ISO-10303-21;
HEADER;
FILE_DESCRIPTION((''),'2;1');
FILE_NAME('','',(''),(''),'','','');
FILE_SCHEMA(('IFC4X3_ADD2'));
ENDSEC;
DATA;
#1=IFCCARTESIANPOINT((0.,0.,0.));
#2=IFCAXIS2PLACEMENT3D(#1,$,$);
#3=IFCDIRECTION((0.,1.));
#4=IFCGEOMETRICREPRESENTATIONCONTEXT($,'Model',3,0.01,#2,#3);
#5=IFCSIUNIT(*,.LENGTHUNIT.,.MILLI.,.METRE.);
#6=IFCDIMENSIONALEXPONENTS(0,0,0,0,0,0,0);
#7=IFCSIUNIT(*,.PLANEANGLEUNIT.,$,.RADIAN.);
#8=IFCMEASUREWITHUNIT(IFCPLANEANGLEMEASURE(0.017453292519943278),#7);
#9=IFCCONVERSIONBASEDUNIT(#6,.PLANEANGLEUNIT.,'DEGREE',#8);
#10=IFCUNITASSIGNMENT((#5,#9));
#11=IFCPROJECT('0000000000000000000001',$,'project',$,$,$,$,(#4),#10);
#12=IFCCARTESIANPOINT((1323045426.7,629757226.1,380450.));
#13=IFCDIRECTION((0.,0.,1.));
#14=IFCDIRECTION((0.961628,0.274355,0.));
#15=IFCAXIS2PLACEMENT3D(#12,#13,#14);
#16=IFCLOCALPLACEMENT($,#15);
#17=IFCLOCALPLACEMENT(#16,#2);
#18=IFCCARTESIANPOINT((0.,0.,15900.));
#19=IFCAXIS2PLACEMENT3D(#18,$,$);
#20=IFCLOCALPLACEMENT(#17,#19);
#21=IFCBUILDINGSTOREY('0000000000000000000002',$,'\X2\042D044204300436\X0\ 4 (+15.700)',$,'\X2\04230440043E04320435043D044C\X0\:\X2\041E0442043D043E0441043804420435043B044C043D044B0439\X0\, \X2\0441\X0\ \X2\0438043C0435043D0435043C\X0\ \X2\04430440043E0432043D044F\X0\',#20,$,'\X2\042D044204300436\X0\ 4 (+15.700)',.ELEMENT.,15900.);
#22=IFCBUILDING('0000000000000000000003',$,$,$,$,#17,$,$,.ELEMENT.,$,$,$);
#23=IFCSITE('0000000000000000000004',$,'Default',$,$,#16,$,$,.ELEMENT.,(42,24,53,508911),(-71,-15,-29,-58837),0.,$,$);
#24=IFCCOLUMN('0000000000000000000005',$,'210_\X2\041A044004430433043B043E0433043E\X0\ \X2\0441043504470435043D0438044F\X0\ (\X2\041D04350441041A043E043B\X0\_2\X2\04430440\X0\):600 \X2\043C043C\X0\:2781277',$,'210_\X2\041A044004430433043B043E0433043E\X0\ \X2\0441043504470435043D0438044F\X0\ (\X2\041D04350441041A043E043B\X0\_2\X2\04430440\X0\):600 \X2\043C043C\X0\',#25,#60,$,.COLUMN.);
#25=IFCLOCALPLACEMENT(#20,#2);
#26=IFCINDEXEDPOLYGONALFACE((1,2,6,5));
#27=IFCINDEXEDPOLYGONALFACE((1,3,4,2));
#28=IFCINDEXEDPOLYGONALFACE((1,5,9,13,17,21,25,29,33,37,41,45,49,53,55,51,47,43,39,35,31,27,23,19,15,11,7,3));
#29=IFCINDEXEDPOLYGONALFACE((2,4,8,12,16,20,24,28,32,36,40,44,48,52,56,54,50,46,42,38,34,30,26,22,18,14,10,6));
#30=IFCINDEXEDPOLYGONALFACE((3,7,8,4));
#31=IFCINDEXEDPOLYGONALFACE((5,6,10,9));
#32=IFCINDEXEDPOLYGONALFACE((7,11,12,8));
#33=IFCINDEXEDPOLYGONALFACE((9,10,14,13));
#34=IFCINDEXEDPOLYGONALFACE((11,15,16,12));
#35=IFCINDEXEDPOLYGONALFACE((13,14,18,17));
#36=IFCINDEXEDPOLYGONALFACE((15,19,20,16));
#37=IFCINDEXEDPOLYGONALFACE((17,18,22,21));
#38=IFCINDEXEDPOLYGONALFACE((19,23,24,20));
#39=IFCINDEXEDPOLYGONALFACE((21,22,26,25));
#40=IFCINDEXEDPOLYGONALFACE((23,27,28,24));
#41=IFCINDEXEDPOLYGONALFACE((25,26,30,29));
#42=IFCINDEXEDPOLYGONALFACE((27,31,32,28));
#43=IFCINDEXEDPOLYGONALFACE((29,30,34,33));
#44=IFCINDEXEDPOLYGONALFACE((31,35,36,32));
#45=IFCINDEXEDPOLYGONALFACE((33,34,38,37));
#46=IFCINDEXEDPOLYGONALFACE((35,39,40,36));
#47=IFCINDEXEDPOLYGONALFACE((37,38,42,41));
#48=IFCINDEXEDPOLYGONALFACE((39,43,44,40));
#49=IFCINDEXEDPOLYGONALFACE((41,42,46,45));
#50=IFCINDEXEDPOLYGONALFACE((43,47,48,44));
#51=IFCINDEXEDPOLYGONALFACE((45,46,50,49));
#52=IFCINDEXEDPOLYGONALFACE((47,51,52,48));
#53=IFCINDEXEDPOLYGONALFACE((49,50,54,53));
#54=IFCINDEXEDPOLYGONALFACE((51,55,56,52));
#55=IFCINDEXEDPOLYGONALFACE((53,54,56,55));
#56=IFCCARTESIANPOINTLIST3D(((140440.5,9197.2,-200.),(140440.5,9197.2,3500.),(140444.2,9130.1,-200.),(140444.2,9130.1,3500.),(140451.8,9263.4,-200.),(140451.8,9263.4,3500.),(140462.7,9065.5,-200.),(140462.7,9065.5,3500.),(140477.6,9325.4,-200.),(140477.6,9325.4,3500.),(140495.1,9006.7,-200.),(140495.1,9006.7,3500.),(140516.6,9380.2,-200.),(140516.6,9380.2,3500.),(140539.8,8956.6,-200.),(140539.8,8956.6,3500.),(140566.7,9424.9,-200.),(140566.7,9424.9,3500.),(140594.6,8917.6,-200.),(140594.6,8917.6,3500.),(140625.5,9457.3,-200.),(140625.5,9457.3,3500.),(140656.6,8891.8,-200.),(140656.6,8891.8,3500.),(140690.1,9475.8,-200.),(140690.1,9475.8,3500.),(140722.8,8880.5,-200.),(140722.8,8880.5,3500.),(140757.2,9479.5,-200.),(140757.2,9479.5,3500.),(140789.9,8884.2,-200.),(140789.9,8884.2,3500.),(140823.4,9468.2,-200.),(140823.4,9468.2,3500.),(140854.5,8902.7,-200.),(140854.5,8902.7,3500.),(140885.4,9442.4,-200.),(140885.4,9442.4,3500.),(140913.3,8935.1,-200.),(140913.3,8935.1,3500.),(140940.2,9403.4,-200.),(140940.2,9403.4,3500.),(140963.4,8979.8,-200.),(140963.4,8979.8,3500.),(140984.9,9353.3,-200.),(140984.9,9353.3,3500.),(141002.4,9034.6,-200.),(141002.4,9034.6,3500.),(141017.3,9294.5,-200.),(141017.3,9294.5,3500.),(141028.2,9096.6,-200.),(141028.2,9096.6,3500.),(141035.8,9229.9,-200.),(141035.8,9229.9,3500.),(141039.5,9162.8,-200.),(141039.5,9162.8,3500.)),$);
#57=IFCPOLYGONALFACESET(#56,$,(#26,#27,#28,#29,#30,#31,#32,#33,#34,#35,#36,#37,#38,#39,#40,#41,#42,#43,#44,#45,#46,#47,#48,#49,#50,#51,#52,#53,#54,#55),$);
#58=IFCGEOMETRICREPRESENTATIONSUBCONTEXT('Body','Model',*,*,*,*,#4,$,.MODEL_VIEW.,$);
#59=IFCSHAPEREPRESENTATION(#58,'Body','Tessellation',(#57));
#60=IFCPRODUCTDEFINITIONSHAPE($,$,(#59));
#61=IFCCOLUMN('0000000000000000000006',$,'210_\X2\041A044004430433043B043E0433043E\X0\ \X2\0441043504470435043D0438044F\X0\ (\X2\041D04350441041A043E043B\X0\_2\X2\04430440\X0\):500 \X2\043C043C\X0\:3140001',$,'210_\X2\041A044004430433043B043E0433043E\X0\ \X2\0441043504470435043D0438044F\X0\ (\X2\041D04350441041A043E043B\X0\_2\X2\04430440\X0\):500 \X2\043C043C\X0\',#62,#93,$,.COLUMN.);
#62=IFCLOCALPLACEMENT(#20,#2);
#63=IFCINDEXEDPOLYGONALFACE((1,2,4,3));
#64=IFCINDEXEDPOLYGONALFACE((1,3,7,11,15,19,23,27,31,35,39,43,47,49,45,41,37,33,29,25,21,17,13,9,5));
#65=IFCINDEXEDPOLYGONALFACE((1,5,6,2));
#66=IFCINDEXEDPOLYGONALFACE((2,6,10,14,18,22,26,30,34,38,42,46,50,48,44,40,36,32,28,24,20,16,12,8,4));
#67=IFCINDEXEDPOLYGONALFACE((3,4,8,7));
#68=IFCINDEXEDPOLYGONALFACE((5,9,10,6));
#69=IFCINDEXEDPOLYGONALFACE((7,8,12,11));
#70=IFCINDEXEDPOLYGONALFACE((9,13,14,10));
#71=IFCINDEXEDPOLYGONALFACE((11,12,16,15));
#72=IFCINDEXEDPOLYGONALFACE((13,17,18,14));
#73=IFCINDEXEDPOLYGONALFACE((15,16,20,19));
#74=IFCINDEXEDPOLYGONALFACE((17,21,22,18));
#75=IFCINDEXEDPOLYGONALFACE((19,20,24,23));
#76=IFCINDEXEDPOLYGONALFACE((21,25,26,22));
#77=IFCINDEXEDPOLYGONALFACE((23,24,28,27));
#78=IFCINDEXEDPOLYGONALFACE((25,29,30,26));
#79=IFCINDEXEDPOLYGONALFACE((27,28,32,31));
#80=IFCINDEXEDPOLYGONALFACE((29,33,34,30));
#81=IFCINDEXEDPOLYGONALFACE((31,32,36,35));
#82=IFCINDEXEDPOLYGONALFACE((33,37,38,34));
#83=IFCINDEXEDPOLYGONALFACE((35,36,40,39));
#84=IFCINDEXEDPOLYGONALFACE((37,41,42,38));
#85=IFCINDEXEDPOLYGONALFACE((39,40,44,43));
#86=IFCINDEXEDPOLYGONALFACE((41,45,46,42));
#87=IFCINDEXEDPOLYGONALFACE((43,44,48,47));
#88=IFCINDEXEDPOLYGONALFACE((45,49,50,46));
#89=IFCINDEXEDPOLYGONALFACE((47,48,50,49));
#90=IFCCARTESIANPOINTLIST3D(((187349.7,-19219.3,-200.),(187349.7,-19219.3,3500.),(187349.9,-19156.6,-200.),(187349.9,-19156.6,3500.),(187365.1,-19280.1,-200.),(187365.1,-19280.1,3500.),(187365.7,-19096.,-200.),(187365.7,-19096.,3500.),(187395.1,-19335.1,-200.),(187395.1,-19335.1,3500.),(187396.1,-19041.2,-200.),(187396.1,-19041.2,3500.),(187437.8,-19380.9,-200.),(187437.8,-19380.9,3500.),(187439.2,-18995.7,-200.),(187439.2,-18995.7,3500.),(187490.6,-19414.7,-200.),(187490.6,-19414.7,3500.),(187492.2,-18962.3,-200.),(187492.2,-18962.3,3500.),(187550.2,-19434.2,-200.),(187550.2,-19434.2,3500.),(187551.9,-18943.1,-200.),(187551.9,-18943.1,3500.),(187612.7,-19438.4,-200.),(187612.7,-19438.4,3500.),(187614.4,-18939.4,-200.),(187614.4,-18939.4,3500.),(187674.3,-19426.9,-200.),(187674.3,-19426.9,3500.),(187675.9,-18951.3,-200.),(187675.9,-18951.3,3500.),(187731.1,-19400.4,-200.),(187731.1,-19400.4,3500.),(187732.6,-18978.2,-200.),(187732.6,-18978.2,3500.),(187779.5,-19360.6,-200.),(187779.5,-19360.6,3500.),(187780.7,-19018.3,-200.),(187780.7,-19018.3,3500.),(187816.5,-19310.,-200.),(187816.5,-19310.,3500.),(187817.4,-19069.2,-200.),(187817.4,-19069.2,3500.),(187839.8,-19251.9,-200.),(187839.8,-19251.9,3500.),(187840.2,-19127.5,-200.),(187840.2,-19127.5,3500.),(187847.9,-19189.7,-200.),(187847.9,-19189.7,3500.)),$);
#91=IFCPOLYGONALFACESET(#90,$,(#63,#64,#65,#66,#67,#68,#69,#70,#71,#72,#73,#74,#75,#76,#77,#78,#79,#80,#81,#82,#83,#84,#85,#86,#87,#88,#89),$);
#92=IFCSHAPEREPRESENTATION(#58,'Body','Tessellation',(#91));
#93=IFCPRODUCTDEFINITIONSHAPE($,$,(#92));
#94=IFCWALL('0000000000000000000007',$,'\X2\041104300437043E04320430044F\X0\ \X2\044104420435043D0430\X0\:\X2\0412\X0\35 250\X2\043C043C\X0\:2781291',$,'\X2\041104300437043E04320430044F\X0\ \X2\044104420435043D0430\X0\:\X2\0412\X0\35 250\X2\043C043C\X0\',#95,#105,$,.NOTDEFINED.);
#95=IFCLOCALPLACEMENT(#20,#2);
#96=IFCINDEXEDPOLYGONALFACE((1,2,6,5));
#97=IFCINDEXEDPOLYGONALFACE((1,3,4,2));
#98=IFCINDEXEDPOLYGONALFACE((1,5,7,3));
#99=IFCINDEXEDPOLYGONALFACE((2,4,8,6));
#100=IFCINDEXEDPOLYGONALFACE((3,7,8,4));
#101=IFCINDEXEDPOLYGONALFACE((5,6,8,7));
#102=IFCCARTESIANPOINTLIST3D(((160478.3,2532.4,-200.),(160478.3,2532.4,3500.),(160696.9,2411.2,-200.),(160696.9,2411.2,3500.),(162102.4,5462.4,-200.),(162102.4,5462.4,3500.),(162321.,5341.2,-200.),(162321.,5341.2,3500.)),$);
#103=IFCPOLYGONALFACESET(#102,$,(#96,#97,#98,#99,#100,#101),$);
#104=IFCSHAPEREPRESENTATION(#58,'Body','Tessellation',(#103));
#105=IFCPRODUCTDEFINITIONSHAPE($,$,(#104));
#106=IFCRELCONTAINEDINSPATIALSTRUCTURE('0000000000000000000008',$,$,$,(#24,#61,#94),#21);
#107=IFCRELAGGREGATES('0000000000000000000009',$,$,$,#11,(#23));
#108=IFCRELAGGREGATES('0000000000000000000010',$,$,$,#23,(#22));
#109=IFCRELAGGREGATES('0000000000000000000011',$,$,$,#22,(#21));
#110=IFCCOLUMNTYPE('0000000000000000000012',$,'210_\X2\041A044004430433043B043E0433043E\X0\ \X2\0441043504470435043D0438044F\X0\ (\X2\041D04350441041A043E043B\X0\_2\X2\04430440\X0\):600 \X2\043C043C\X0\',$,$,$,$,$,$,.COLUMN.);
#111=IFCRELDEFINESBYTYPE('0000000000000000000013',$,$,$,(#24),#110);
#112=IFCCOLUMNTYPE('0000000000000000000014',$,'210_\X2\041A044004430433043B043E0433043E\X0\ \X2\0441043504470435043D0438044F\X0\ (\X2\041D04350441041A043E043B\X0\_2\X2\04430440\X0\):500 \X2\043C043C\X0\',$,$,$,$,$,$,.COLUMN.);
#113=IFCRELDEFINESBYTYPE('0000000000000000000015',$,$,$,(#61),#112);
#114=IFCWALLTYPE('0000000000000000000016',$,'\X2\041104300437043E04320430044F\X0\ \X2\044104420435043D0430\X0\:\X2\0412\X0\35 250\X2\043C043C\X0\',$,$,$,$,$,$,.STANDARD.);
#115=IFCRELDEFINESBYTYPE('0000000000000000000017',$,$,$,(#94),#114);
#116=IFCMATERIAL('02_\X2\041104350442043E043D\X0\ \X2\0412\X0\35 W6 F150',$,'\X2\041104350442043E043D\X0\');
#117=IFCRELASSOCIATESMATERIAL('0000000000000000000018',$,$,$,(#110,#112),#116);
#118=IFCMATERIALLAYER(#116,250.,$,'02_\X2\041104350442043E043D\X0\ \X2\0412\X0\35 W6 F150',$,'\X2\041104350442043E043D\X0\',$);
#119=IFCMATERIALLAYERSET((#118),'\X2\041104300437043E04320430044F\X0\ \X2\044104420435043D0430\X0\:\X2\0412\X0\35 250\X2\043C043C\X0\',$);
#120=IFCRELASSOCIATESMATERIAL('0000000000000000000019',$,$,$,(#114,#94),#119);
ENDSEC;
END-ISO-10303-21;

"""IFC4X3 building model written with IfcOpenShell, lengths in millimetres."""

from ifc_helpers import new_model, entity, si_unit, converted_unit, direction, frame, frame_2d, origin, origin_2d_with_axis, place, context, subcontext, project, spatial, rectangle, circle, extrude, source, transform, mapped, material, layer, layer_set, material_profile, profile_set, type_object, type_shapes, element, save


model = new_model("IFC4X3")

# Units and contexts
model_context = context("Model", 3, precision=0.01, world=origin(), true_north=direction((0.0, 1.0)))
body_context = subcontext(model_context, "Body", "Model", "MODEL_VIEW")
ifc_project = project(units=[si_unit("LENGTHUNIT", "METRE", prefix="MILLI"), converted_unit("PLANEANGLEUNIT", "DEGREE", entity("IfcPlaneAngleMeasure", 0.017453292519943278), si_unit("PLANEANGLEUNIT", "RADIAN"), dimensions=[0, 0, 0, 0, 0, 0, 0])], contexts=[model_context])

# Site, building, storey
site_placement = place(None, frame((1323045426.7, 629757226.1, 380450.0), z_axis=(0.0, 0.0, 1.0), x_axis=(0.961628, 0.274355, 0.0)))
site = spatial("IfcSite", under=ifc_project, at=site_placement, Name="Default", CompositionType="ELEMENT", RefLatitude=(42, 24, 53, 508911), RefLongitude=(-71, -15, -29, -58837), RefElevation=0.0)
building_placement = place(site_placement, origin())
building = spatial("IfcBuilding", under=site, at=building_placement, CompositionType="ELEMENT")
storey_placement = place(building_placement, frame((0.0, 0.0, 15900.0)))
storey = spatial("IfcBuildingStorey", under=building, at=storey_placement, Name="Этаж 4 (+15.700)", ObjectType="Уровень:Относительный, с именем уровня", LongName="Этаж 4 (+15.700)", CompositionType="ELEMENT", Elevation=15900.0)

# Columns
ifc_material = material(Name="02_Бетон В35 W6 F150", Category="Бетон")
ifc_material_profile_1 = material_profile(ifc_material, circle(Radius=300.0, at=frame_2d((0.0, 0.0), x_axis=(1.0, 0.0))), Name="600 мм")
ifc_profile_set_1 = profile_set([ifc_material_profile_1], Name="600 мм")
column_type_1 = type_object("IfcColumnType", Name="210_Круглого сечения (НесКол_2ур):600 мм", PredefinedType="COLUMN", material=ifc_profile_set_1)
shared_shape_1 = source(origin(), body_context, "Body", "SweptSolid", [
    extrude(circle(Radius=300.0, at=frame_2d((0.0, 0.0), x_axis=(1.0, 0.0))), frame((140740.0, 9180.0, 15700.0), z_axis=(0.0, 0.0, 1.0), x_axis=(0.87462, -0.48481, 0.0)), (0.0, 0.0, 1.0), 3700.0),
])
type_shapes(column_type_1, [shared_shape_1])
column_1_placement = place(storey_placement, frame((0.0, 0.0, -15900.0)))
element("IfcColumn", 1, at=column_1_placement, inside=storey, type_object=column_type_1, Name="210_Круглого сечения (НесКол_2ур):600 мм:2781277", ObjectType="210_Круглого сечения (НесКол_2ур):600 мм", PredefinedType="COLUMN", context=body_context, shape_type="MappedRepresentation", body=[
    mapped(shared_shape_1, transform((0.0, 0.0, 0.0), scale=1.0)),
])
ifc_material_profile_2 = material_profile(ifc_material, circle(Radius=250.0, at=origin_2d_with_axis()), Name="500 мм")
ifc_profile_set_2 = profile_set([ifc_material_profile_2], Name="500 мм")
column_type_2 = type_object("IfcColumnType", Name="210_Круглого сечения (НесКол_2ур):500 мм", PredefinedType="COLUMN", material=ifc_profile_set_2)
shared_shape_2 = source(origin(), body_context, "Body", "SweptSolid", [
    extrude(circle(Radius=250.0, at=origin_2d_with_axis()), frame((187597.9, -19188.8, 15700.0), z_axis=(0.0, 0.0, 1.0), x_axis=(0.87462, -0.48481, 0.0)), (0.0, 0.0, 1.0), 3700.0),
])
type_shapes(column_type_2, [shared_shape_2])
column_2_placement = place(storey_placement, frame((0.0, 0.0, -15900.0)))
element("IfcColumn", 2, at=column_2_placement, inside=storey, type_object=column_type_2, Name="210_Круглого сечения (НесКол_2ур):500 мм:3140001", ObjectType="210_Круглого сечения (НесКол_2ур):500 мм", PredefinedType="COLUMN", context=body_context, shape_type="MappedRepresentation", body=[
    mapped(shared_shape_2, transform((0.0, 0.0, 0.0), scale=1.0)),
])

# Shared definitions
ifc_layer = layer(ifc_material, 250.0, Name="02_Бетон В35 W6 F150", Category="Бетон")
ifc_layer_set = layer_set([ifc_layer], Name="Базовая стена:В35 250мм")
wall_type = type_object("IfcWallType", Name="Базовая стена:В35 250мм", PredefinedType="STANDARD", material=ifc_layer_set)

# Wall
wall_1_placement = place(storey_placement, frame((160587.6, 2471.8, -200.0), z_axis=(0.0, 0.0, 1.0), x_axis=(0.48481, 0.87462, 0.0)))
element("IfcWall", 3, at=wall_1_placement, inside=storey, type_object=wall_type, material=ifc_layer_set, Name="Базовая стена:В35 250мм:2781291", ObjectType="Базовая стена:В35 250мм", PredefinedType="NOTDEFINED", context=body_context, shape_type="SweptSolid", body=[
    extrude(rectangle(XDim=3350.0, YDim=250.0, at=frame_2d((1675.0, 0.0), x_axis=(-1.0, 0.0))), origin(), (0.0, 0.0, 1.0), 3700.0),
])

save(model, "model.ifc")
